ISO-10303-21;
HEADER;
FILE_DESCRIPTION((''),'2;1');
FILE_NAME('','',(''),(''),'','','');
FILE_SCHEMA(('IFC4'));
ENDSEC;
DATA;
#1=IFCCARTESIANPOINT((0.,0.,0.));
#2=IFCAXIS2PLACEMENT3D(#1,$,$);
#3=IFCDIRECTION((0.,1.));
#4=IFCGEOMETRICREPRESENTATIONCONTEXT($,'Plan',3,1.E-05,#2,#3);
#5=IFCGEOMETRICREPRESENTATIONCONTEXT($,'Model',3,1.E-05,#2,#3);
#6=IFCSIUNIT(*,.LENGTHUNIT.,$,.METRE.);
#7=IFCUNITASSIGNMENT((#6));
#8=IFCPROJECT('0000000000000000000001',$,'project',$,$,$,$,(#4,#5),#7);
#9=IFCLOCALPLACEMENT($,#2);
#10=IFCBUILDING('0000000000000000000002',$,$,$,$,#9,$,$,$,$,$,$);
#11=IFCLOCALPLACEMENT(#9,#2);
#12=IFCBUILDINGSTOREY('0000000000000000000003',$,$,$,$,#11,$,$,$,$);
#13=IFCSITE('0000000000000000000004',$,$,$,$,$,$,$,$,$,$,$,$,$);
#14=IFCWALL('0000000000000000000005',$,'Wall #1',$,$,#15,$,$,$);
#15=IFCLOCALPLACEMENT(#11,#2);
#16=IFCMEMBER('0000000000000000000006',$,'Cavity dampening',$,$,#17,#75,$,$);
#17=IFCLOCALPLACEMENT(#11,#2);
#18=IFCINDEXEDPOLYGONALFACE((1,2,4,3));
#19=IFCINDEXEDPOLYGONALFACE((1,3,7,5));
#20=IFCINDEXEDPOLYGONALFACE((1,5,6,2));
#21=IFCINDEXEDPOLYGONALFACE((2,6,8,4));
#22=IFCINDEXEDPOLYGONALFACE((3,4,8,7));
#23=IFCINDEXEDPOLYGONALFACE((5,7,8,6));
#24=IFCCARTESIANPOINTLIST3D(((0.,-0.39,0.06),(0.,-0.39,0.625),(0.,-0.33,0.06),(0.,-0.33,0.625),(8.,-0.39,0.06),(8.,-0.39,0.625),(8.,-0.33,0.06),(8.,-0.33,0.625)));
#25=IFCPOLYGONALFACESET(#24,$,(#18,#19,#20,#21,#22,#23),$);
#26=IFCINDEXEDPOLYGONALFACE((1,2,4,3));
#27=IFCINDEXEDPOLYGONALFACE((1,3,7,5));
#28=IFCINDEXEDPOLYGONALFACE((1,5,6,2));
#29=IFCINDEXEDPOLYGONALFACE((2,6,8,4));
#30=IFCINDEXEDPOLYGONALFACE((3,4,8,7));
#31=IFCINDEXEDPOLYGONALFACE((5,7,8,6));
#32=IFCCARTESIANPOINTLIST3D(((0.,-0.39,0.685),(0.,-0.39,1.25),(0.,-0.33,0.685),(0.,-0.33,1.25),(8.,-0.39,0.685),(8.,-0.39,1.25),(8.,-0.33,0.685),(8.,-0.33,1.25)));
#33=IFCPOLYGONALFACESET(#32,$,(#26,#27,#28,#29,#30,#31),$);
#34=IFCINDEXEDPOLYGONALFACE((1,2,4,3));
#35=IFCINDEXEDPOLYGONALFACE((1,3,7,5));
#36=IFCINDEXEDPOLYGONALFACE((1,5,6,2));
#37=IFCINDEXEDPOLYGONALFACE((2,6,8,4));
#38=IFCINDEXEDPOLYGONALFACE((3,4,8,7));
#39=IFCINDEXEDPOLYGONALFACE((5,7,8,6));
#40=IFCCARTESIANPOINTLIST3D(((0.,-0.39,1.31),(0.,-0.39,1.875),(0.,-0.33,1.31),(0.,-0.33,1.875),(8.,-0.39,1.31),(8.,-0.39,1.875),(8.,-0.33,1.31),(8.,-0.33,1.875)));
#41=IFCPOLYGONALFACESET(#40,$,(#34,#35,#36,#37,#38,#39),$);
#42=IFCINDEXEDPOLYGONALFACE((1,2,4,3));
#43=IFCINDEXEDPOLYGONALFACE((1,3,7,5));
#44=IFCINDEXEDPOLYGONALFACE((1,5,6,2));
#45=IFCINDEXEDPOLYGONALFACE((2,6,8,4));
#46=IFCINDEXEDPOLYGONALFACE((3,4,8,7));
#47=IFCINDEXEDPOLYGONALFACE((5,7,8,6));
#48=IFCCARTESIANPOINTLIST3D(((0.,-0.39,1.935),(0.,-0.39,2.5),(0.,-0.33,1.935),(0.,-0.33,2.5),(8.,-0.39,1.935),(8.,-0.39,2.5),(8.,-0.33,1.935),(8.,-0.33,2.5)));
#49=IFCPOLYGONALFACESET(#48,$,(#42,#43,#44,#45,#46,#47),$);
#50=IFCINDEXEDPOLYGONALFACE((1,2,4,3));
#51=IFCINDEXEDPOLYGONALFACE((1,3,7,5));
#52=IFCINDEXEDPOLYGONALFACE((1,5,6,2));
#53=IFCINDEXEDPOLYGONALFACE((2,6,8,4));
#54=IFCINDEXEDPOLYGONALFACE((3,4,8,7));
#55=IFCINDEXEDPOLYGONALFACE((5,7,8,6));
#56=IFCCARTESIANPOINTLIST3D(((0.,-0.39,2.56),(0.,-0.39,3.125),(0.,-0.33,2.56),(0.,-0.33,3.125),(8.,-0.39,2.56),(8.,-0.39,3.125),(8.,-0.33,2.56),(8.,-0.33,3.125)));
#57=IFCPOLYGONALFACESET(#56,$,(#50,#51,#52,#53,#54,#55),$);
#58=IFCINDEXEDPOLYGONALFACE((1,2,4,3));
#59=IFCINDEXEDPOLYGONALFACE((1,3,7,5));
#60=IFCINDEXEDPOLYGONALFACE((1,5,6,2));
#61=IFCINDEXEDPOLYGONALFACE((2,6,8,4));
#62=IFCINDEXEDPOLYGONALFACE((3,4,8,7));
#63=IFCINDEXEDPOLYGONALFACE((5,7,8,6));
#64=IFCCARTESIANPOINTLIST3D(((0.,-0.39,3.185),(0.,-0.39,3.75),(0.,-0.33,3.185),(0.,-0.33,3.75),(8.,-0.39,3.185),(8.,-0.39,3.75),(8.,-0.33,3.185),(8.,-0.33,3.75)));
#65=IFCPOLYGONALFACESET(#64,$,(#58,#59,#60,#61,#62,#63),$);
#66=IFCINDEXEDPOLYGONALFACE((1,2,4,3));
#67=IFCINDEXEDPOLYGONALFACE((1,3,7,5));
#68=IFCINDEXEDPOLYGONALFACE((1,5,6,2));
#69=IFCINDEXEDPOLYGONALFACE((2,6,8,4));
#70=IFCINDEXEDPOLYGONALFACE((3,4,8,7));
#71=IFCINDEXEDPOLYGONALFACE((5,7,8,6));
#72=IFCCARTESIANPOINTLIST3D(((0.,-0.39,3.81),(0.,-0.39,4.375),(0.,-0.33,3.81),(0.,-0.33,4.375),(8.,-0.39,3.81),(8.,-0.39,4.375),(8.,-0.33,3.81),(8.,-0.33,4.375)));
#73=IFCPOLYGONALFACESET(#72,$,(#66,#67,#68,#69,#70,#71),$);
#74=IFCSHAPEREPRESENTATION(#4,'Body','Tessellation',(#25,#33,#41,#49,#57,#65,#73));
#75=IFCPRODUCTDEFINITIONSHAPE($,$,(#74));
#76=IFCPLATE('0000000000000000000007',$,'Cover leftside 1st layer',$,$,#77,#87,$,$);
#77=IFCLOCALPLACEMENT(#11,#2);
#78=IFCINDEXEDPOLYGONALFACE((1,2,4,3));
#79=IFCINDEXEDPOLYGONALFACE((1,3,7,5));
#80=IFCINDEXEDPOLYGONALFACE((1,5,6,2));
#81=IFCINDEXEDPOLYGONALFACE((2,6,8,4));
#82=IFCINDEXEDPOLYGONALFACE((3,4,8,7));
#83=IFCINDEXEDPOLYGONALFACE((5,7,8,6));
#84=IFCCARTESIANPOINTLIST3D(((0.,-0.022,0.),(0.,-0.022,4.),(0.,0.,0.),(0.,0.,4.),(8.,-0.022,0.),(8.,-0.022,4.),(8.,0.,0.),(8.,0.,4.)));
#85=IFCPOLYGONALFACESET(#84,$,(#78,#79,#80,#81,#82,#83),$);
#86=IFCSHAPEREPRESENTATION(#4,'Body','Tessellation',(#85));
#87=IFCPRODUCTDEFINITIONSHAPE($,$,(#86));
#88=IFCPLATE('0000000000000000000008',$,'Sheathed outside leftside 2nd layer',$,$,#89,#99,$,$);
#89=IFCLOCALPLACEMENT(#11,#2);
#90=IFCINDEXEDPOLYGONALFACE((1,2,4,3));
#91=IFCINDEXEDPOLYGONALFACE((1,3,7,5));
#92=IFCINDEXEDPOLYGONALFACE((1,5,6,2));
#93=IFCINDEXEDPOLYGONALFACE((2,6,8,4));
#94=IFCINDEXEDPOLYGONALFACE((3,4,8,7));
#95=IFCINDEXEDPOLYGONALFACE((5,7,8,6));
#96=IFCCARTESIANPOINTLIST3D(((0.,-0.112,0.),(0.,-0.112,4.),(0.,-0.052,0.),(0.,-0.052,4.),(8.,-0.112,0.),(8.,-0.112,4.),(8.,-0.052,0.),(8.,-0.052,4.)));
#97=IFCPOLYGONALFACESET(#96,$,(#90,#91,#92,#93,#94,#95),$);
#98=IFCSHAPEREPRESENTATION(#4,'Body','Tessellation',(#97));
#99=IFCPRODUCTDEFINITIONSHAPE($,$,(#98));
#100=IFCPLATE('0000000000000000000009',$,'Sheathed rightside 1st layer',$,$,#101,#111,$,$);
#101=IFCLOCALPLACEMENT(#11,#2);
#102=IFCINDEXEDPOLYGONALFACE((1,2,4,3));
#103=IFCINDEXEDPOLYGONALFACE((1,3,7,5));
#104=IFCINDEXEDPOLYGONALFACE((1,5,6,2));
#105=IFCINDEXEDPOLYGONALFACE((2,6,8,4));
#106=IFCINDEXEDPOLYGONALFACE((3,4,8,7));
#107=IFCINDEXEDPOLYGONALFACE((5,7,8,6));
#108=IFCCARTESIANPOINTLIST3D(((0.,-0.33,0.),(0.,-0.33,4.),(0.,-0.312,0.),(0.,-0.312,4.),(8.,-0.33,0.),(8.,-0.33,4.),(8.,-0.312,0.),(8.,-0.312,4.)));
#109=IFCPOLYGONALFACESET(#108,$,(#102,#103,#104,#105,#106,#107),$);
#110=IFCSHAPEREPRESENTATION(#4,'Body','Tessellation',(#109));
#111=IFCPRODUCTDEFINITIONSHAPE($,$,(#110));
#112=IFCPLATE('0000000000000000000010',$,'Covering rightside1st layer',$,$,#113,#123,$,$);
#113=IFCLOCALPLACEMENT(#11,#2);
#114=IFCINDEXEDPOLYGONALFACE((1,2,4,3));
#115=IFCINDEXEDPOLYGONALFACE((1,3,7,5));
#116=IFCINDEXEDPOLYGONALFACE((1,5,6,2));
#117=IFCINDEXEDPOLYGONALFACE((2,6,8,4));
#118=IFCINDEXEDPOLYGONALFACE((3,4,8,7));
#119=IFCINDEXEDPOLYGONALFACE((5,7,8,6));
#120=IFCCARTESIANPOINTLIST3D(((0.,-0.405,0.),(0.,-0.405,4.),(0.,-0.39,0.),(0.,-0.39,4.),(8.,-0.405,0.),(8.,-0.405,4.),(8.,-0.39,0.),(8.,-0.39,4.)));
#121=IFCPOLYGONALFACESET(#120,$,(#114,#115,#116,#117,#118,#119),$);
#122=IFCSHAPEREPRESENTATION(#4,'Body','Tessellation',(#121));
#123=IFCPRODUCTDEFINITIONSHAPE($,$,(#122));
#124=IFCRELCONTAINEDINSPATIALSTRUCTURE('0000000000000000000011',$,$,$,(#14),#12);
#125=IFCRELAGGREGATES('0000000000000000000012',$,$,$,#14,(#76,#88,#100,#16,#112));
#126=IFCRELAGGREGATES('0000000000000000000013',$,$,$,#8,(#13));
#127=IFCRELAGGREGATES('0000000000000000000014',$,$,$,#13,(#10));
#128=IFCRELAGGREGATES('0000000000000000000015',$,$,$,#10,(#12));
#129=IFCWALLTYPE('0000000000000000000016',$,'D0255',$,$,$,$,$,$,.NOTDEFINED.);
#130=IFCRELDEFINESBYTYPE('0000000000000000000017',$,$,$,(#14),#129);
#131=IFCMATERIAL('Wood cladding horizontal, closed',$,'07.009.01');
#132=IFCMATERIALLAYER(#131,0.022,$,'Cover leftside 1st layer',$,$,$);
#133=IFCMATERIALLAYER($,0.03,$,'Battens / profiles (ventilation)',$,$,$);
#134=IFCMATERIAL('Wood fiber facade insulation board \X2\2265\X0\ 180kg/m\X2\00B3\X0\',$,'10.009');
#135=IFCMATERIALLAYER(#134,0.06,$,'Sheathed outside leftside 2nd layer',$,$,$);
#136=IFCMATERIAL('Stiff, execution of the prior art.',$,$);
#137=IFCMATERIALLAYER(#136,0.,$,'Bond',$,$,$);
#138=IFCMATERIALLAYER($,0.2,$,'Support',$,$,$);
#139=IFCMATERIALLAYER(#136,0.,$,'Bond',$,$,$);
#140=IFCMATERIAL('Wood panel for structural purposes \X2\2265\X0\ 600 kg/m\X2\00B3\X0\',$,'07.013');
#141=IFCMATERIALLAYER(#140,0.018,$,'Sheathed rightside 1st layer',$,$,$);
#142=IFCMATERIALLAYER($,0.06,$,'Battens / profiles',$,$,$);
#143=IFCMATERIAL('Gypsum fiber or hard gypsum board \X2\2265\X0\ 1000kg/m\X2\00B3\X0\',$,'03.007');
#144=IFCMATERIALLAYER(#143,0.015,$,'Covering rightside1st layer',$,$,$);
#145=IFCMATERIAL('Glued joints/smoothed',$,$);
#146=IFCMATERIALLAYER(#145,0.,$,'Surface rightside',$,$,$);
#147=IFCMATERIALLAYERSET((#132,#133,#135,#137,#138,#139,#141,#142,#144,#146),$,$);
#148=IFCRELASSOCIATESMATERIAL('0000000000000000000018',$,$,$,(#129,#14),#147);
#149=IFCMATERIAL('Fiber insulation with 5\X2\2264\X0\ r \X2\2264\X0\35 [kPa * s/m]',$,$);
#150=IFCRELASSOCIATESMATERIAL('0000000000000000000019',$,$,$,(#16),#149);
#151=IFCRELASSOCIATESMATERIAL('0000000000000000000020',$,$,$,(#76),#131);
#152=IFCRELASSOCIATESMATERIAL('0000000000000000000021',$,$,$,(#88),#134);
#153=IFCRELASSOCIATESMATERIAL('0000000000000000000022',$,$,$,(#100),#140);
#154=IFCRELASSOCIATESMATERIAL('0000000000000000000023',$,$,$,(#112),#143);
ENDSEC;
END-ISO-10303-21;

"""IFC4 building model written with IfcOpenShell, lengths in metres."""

from ifc_helpers import new_model, si_unit, direction, frame, frame_2d, origin, origin_with_axes, place, context, project, spatial, rectangle, extrude, material, layer, layer_set, type_object, element, aggregate, save


model = new_model("IFC4")

# Units and contexts
plan_context = context("Plan", 3, precision=1e-05, world=origin(), true_north=direction((0.0, 1.0)))
model_context = context("Model", 3, precision=1e-05, world=origin(), true_north=direction((0.0, 1.0)))
ifc_project = project(units=[si_unit("LENGTHUNIT", "METRE")], contexts=[plan_context, model_context])

# Site, building, storey
site = spatial("IfcSite", under=ifc_project)
building_placement = place(None, origin())
building = spatial("IfcBuilding", under=site, at=building_placement)
storey_placement = place(building_placement, origin())
storey = spatial("IfcBuildingStorey", under=building, at=storey_placement)

# Wall, member, plates
ifc_material_1 = material(Name="Wood cladding horizontal, closed", Category="07.009.01")
ifc_layer_1 = layer(ifc_material_1, 0.022, Name="Cover leftside 1st layer")
ifc_layer_2 = layer(None, 0.03, Name="Battens / profiles (ventilation)")
ifc_material_2 = material(Name="Wood fiber facade insulation board ≥ 180kg/m³", Category="10.009")
ifc_layer_3 = layer(ifc_material_2, 0.06, Name="Sheathed outside leftside 2nd layer")
ifc_material_3 = material(Name="Stiff, execution of the prior art.")
ifc_layer_4 = layer(ifc_material_3, 0.0, Name="Bond")
ifc_layer_5 = layer(None, 0.2, Name="Support")
ifc_layer_6 = layer(ifc_material_3, 0.0, Name="Bond")
ifc_material_4 = material(Name="Wood panel for structural purposes ≥ 600 kg/m³", Category="07.013")
ifc_layer_7 = layer(ifc_material_4, 0.018, Name="Sheathed rightside 1st layer")
ifc_layer_8 = layer(None, 0.06, Name="Battens / profiles")
ifc_material_5 = material(Name="Gypsum fiber or hard gypsum board ≥ 1000kg/m³", Category="03.007")
ifc_layer_9 = layer(ifc_material_5, 0.015, Name="Covering rightside1st layer")
ifc_material_6 = material(Name="Glued joints/smoothed")
ifc_layer_10 = layer(ifc_material_6, 0.0, Name="Surface rightside")
ifc_layer_set = layer_set([ifc_layer_1, ifc_layer_2, ifc_layer_3, ifc_layer_4, ifc_layer_5, ifc_layer_6, ifc_layer_7, ifc_layer_8, ifc_layer_9, ifc_layer_10])
wall_type = type_object("IfcWallType", Name="D0255", PredefinedType="NOTDEFINED", material=ifc_layer_set)
wall_placement = place(None, frame((0.0, 0.0, 0.0), z_axis=(0.0, -1.0, 0.0), x_axis=(1.0, 0.0, 0.0)))
wall = element("IfcWall", 1, at=wall_placement, inside=storey, type_object=wall_type, material=ifc_layer_set, Name="Wall #1")
ifc_material_7 = material(Name="Fiber insulation with 5≤ r ≤35 [kPa * s/m]")
member_1_placement = place(wall_placement, origin())
member_1 = element("IfcMember", 2, at=member_1_placement, material=ifc_material_7, Name="Cavity dampening", context=plan_context, shape_type="SweptSolid", body=[
    extrude(rectangle(XDim=0.565, YDim=0.06, at=frame_2d((0.2825, 0.03), x_axis=(1.0, 0.0))), frame((0.0, 0.06, 0.33), z_axis=(1.0, 0.0, 0.0), x_axis=(0.0, 1.0, 0.0)), (0.0, 0.0, 1.0), 8.0),
    extrude(rectangle(XDim=0.565, YDim=0.06, at=frame_2d((0.2825, 0.03), x_axis=(1.0, 0.0))), frame((0.0, 0.685, 0.33), z_axis=(1.0, 0.0, 0.0), x_axis=(0.0, 1.0, 0.0)), (0.0, 0.0, 1.0), 8.0),
    extrude(rectangle(XDim=0.565, YDim=0.06, at=frame_2d((0.2825, 0.03), x_axis=(1.0, 0.0))), frame((0.0, 1.31, 0.33), z_axis=(1.0, 0.0, 0.0), x_axis=(0.0, 1.0, 0.0)), (0.0, 0.0, 1.0), 8.0),
    extrude(rectangle(XDim=0.565, YDim=0.06, at=frame_2d((0.2825, 0.03), x_axis=(1.0, 0.0))), frame((0.0, 1.935, 0.33), z_axis=(1.0, 0.0, 0.0), x_axis=(0.0, 1.0, 0.0)), (0.0, 0.0, 1.0), 8.0),
    extrude(rectangle(XDim=0.565, YDim=0.06, at=frame_2d((0.2825, 0.03), x_axis=(1.0, 0.0))), frame((0.0, 2.56, 0.33), z_axis=(1.0, 0.0, 0.0), x_axis=(0.0, 1.0, 0.0)), (0.0, 0.0, 1.0), 8.0),
    extrude(rectangle(XDim=0.565, YDim=0.06, at=frame_2d((0.2825, 0.03), x_axis=(1.0, 0.0))), frame((0.0, 3.185, 0.33), z_axis=(1.0, 0.0, 0.0), x_axis=(0.0, 1.0, 0.0)), (0.0, 0.0, 1.0), 8.0),
    extrude(rectangle(XDim=0.565, YDim=0.06, at=frame_2d((0.2825, 0.03), x_axis=(1.0, 0.0))), frame((0.0, 3.81, 0.33), z_axis=(1.0, 0.0, 0.0), x_axis=(0.0, 1.0, 0.0)), (0.0, 0.0, 1.0), 8.0),
])
plate_1_placement = place(wall_placement, origin())
plate_1 = element("IfcPlate", 3, at=plate_1_placement, material=ifc_material_1, Name="Cover leftside 1st layer", context=plan_context, shape_type="SweptSolid", body=[
    extrude(rectangle(XDim=8.0, YDim=4.0, at=frame_2d((4.0, 2.0), x_axis=(1.0, 0.0))), origin_with_axes(), (0.0, 0.0, 1.0), 0.022),
])
plate_2_placement = place(wall_placement, origin())
plate_2 = element("IfcPlate", 4, at=plate_2_placement, material=ifc_material_2, Name="Sheathed outside leftside 2nd layer", context=plan_context, shape_type="SweptSolid", body=[
    extrude(rectangle(XDim=8.0, YDim=4.0, at=frame_2d((4.0, 2.0), x_axis=(1.0, 0.0))), frame((0.0, 0.0, 0.052), z_axis=(0.0, 0.0, 1.0), x_axis=(1.0, 0.0, 0.0)), (0.0, 0.0, 1.0), 0.06),
])
plate_3_placement = place(wall_placement, origin())
plate_3 = element("IfcPlate", 5, at=plate_3_placement, material=ifc_material_4, Name="Sheathed rightside 1st layer", context=plan_context, shape_type="SweptSolid", body=[
    extrude(rectangle(XDim=8.0, YDim=4.0, at=frame_2d((4.0, 2.0), x_axis=(1.0, 0.0))), frame((0.0, 0.0, 0.312), z_axis=(0.0, 0.0, 1.0), x_axis=(1.0, 0.0, 0.0)), (0.0, 0.0, 1.0), 0.018),
])
plate_4_placement = place(wall_placement, origin())
plate_4 = element("IfcPlate", 6, at=plate_4_placement, material=ifc_material_5, Name="Covering rightside1st layer", context=plan_context, shape_type="SweptSolid", body=[
    extrude(rectangle(XDim=8.0, YDim=4.0, at=frame_2d((4.0, 2.0), x_axis=(1.0, 0.0))), frame((0.0, 0.0, 0.39), z_axis=(0.0, 0.0, 1.0), x_axis=(1.0, 0.0, 0.0)), (0.0, 0.0, 1.0), 0.015),
])
aggregate(wall, [plate_1, plate_2, plate_3, member_1, plate_4])

save(model, "model.ifc")
